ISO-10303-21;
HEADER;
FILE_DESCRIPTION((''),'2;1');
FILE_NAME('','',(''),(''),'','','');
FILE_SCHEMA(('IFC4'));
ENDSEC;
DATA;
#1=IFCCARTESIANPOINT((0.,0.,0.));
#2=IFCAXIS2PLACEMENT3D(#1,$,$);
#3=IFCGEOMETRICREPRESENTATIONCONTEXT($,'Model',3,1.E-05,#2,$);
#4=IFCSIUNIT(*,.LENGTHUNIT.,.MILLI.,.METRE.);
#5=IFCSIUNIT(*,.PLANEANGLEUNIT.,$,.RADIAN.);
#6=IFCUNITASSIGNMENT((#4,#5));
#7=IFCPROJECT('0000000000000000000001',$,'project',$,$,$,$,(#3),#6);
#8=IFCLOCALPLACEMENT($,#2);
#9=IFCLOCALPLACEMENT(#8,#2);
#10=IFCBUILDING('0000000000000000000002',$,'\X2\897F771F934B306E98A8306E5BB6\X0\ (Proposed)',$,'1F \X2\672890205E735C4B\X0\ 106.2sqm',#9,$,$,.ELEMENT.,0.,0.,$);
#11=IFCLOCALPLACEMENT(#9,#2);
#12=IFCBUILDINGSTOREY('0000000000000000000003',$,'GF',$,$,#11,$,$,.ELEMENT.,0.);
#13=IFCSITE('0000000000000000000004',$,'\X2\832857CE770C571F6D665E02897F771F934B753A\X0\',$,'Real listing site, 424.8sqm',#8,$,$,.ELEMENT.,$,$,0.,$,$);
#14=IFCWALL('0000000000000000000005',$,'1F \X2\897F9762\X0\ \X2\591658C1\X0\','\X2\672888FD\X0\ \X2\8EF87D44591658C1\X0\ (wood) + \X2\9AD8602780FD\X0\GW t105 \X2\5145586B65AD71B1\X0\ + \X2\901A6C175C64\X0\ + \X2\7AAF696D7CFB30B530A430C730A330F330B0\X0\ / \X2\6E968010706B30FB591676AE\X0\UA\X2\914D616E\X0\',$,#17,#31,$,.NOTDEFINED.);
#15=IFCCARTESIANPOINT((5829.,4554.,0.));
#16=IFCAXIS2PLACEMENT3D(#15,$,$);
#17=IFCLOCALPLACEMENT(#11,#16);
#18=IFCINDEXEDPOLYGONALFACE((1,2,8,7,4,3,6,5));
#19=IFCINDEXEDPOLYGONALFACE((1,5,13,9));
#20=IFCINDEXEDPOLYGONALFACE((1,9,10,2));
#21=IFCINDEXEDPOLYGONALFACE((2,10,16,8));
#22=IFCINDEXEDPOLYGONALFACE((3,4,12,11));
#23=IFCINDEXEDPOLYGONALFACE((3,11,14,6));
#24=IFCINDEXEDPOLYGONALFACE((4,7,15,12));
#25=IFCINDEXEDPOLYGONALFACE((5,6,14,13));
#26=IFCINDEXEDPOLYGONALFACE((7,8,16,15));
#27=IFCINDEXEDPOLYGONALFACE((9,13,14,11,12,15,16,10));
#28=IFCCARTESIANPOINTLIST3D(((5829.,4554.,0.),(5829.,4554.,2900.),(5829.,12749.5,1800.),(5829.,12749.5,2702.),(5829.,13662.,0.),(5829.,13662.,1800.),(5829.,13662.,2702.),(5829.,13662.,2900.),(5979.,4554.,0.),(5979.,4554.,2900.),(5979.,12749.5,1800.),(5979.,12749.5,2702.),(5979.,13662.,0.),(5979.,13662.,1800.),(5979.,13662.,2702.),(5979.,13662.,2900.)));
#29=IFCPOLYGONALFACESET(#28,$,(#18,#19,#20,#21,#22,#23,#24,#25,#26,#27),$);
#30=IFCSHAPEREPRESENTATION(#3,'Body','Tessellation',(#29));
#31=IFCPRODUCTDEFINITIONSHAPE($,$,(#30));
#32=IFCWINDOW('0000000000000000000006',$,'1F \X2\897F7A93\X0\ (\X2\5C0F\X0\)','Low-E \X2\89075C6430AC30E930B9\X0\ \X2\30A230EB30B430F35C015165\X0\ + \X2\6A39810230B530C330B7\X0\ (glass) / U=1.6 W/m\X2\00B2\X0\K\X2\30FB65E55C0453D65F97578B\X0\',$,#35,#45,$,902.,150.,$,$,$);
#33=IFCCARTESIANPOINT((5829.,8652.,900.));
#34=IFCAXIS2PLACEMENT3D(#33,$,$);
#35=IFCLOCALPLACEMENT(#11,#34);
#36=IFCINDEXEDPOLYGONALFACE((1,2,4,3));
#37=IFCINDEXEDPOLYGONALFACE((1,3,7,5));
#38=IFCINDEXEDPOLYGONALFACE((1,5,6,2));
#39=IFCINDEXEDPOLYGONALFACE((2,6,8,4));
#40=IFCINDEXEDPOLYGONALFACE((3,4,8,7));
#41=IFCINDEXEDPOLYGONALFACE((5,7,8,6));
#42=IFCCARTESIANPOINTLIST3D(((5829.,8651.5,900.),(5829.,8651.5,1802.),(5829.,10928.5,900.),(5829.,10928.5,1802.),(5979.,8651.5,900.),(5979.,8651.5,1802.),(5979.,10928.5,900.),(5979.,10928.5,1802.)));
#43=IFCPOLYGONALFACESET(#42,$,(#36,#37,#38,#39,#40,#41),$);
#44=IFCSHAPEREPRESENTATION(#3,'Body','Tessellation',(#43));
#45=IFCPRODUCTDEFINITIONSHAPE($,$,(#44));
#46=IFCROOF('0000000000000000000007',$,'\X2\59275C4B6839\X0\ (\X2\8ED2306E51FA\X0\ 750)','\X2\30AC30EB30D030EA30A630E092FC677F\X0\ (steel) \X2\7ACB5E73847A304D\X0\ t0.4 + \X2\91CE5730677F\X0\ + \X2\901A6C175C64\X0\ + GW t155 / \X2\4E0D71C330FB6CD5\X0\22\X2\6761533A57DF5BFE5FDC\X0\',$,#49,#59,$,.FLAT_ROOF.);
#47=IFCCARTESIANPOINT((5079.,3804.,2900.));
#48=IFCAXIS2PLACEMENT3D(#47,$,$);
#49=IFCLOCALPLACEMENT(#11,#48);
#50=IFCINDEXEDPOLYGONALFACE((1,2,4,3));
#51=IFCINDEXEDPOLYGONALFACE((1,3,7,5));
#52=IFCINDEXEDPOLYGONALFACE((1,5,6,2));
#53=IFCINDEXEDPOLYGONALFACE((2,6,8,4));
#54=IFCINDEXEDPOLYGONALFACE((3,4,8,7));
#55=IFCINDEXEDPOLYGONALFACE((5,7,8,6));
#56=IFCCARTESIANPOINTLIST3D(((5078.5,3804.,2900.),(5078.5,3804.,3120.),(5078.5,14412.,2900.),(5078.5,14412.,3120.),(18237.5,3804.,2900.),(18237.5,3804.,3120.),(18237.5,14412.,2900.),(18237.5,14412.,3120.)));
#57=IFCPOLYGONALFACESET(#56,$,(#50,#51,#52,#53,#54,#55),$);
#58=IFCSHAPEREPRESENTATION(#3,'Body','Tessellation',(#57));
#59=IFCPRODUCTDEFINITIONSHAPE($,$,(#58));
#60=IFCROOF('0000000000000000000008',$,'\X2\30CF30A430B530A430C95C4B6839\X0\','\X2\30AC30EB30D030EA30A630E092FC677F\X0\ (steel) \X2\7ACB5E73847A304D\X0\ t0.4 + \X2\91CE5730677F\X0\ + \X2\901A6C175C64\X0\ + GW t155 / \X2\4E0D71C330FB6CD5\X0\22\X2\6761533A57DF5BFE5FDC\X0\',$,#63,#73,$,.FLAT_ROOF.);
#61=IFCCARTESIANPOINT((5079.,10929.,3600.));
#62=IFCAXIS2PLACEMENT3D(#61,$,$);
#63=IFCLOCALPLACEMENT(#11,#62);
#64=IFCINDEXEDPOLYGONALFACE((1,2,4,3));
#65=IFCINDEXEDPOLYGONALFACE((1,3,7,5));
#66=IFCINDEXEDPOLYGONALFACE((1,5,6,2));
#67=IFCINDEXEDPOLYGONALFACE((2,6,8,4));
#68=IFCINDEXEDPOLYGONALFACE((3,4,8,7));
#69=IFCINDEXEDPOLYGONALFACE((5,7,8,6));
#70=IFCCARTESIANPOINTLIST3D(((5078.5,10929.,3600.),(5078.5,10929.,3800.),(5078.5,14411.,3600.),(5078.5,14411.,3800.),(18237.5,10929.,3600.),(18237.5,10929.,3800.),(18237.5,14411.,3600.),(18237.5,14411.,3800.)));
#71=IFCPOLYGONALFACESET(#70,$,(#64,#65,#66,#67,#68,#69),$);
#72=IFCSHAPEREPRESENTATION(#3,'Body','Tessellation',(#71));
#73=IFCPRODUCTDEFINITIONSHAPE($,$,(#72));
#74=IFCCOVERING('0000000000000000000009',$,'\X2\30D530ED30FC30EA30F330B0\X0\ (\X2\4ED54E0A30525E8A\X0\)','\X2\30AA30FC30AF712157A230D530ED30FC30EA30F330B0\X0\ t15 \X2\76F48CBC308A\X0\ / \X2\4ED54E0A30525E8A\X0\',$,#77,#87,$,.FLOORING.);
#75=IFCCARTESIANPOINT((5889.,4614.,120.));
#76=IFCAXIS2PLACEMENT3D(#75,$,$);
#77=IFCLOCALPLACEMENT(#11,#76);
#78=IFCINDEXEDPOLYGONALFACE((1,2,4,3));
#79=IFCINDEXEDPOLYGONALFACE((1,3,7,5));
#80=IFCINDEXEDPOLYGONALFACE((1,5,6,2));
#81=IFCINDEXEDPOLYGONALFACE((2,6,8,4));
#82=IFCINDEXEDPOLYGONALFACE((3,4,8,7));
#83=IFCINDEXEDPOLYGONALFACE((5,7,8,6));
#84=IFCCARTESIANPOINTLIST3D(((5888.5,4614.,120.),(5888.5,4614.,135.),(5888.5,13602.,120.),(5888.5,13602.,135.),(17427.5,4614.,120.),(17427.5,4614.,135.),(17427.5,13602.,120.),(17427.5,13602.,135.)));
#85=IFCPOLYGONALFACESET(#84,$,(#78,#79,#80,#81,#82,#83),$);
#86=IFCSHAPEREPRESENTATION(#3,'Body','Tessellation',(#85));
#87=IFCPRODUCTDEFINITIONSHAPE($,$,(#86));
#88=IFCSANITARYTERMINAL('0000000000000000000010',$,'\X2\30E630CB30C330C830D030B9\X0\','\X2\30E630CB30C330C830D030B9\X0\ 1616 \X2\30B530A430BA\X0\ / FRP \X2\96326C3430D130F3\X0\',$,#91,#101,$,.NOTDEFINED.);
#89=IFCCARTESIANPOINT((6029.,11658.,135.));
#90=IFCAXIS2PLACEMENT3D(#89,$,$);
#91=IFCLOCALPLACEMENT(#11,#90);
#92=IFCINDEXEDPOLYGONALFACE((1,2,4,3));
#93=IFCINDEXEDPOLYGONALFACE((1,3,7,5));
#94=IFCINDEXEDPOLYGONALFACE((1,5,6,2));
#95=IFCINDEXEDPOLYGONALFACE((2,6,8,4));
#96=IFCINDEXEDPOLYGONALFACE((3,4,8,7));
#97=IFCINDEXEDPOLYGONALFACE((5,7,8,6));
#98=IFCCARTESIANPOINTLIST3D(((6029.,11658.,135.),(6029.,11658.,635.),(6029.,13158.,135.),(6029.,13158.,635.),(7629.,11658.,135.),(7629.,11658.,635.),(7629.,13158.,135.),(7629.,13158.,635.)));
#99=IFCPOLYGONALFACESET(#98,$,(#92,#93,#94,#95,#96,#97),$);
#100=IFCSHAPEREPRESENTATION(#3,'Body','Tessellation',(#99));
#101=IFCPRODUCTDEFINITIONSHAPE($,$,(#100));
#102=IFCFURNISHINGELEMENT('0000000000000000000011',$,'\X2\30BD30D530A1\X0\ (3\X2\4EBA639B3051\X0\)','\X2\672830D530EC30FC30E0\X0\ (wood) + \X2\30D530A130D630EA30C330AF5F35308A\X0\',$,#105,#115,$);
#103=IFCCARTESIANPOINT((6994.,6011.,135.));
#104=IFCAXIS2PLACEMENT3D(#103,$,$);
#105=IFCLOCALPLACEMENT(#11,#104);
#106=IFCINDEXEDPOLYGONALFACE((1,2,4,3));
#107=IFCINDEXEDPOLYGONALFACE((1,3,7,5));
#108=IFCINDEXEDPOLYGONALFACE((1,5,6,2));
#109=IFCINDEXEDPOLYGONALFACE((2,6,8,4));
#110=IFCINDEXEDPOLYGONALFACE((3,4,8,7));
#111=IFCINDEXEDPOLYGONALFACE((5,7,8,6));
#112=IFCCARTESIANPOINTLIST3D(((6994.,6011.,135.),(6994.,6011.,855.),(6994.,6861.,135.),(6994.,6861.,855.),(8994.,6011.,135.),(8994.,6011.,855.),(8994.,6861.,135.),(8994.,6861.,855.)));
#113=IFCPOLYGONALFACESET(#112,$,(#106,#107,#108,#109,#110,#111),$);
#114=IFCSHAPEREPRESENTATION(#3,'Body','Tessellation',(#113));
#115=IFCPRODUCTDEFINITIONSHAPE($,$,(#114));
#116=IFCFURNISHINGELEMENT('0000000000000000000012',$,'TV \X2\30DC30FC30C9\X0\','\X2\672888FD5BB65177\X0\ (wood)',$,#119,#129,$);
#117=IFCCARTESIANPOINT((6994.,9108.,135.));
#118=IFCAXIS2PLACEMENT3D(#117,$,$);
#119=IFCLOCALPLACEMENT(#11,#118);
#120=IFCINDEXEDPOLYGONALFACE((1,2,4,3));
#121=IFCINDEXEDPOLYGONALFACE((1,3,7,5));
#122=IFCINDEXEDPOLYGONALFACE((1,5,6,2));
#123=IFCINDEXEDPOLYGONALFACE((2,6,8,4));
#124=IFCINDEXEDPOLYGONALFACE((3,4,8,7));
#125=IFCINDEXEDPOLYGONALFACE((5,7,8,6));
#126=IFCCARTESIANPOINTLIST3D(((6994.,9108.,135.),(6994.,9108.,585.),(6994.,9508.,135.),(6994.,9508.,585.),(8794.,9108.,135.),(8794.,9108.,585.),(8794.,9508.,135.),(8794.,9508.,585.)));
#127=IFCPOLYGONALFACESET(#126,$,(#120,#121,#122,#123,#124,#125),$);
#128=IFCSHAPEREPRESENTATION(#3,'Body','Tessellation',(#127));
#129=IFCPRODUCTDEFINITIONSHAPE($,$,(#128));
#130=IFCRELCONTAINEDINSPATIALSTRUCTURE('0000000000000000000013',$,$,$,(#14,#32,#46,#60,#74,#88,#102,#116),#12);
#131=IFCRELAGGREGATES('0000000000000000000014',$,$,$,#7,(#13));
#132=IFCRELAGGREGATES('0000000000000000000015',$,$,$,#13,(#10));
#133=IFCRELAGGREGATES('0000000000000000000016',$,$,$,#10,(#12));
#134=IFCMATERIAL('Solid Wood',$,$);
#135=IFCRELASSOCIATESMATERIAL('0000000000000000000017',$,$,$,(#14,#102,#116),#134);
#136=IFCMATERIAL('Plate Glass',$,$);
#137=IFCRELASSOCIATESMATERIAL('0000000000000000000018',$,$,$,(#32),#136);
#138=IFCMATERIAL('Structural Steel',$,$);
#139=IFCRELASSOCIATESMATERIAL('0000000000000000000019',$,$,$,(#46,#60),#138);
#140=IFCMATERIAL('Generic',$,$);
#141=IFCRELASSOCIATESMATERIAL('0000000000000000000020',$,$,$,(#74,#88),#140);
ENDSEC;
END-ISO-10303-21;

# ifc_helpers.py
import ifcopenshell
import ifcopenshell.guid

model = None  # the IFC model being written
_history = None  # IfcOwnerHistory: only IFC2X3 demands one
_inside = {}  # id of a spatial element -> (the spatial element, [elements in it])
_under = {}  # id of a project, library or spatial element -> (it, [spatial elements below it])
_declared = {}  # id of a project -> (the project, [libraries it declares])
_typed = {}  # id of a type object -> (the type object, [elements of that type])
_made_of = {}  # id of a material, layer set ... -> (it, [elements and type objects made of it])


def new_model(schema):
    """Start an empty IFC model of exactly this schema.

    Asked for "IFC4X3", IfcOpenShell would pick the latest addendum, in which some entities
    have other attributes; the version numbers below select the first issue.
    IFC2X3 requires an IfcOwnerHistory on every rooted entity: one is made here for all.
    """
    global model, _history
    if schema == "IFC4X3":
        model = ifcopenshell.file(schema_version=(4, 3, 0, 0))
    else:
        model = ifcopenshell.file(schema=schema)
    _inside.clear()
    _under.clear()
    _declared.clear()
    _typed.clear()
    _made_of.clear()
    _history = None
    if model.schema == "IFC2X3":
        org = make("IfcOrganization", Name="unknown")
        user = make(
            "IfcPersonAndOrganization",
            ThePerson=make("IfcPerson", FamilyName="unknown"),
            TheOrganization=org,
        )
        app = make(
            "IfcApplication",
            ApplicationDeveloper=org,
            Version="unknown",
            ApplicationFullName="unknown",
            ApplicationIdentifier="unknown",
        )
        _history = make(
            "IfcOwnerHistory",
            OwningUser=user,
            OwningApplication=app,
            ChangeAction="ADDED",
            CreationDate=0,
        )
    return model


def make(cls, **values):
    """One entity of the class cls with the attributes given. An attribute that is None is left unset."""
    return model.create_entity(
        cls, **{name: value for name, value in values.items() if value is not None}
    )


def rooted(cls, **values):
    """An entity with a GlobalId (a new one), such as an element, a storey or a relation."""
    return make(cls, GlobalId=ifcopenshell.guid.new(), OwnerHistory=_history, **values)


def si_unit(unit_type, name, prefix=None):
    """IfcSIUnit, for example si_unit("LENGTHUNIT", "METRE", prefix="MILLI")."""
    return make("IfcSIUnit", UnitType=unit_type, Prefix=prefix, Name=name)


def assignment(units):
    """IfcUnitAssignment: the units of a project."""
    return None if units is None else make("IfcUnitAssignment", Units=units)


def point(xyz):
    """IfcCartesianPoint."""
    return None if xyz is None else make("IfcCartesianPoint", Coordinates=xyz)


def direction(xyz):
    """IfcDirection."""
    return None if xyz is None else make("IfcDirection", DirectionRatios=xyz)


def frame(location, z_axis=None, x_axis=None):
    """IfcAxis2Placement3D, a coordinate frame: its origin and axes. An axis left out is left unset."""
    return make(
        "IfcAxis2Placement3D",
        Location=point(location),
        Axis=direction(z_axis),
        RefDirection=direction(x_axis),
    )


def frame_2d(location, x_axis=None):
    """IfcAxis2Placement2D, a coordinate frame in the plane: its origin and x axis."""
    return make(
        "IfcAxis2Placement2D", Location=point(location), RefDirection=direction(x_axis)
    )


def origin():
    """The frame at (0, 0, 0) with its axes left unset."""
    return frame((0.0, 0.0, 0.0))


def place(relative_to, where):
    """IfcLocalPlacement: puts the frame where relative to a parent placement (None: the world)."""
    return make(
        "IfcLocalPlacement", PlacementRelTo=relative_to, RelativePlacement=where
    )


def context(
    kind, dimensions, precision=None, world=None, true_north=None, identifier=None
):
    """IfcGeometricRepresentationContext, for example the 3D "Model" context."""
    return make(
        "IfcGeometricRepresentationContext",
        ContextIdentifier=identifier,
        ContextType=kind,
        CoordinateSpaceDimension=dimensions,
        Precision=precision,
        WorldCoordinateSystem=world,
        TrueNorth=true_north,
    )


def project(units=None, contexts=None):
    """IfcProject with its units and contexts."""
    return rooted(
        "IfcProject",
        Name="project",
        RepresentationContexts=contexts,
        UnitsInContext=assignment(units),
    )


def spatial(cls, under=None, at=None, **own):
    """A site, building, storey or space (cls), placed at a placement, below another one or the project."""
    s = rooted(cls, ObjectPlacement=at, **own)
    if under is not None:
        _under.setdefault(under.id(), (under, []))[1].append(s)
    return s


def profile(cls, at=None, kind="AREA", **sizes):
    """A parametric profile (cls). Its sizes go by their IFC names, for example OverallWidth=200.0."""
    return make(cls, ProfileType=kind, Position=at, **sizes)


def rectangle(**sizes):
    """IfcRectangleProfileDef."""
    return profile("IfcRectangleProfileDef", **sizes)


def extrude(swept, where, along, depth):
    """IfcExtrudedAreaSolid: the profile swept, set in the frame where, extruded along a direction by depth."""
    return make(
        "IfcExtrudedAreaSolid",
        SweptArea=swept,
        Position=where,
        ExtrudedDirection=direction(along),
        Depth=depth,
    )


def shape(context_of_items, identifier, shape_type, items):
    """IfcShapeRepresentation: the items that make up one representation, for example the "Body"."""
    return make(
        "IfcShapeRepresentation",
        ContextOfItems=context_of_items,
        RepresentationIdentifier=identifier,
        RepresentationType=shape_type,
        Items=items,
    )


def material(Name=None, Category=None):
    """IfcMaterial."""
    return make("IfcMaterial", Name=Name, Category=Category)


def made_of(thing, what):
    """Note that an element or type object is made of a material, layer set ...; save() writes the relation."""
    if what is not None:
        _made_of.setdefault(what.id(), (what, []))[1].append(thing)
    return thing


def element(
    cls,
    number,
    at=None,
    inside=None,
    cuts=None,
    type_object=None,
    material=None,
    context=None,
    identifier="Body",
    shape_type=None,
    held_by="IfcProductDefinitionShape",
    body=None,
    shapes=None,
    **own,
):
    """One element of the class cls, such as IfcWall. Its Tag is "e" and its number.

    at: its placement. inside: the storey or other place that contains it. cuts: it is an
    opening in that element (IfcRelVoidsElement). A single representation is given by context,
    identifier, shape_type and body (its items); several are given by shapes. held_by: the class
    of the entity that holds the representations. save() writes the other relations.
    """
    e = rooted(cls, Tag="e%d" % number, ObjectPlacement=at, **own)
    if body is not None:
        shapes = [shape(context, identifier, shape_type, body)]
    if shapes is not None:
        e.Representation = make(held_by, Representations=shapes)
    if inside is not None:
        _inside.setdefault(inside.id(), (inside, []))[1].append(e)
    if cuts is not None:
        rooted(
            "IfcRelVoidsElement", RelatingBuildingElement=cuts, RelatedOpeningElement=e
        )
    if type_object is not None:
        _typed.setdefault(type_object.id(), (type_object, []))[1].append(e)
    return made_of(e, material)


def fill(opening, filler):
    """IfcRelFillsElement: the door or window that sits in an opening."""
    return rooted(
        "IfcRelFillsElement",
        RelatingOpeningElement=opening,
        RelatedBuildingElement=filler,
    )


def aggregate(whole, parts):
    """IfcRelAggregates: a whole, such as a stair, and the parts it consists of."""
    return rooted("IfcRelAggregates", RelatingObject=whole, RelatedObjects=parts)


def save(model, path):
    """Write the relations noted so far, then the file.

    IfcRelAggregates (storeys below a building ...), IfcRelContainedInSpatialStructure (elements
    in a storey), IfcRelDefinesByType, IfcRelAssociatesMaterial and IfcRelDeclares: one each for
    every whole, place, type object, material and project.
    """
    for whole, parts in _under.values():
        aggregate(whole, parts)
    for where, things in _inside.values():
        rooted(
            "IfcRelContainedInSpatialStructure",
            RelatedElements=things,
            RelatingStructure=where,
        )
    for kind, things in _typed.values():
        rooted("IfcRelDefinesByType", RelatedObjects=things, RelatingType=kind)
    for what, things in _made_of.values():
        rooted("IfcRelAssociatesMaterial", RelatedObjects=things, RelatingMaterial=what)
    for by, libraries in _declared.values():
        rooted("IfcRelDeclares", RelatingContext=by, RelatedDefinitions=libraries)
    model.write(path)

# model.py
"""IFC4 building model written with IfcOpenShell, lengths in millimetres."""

from ifc_helpers import new_model, si_unit, frame, frame_2d, origin, place, context, project, spatial, rectangle, extrude, material, element, fill, save


model = new_model("IFC4")

# Units and contexts
model_context = context("Model", 3, precision=1e-05, world=origin())
ifc_project = project(units=[si_unit("LENGTHUNIT", "METRE", prefix="MILLI"), si_unit("PLANEANGLEUNIT", "RADIAN")], contexts=[model_context])

# Site, building, storey
site_placement = place(None, origin())
site = spatial("IfcSite", under=ifc_project, at=site_placement, Name="茨城県土浦市西真鍋町", ObjectType="Real listing site, 424.8sqm", CompositionType="ELEMENT", RefElevation=0.0)
building_placement = place(site_placement, origin())
building = spatial("IfcBuilding", under=site, at=building_placement, Name="西真鍋の風の家 (Proposed)", ObjectType="1F 木造平屋 106.2sqm", CompositionType="ELEMENT", ElevationOfRefHeight=0.0, ElevationOfTerrain=0.0)
storey_placement = place(building_placement, origin())
storey = spatial("IfcBuildingStorey", under=building, at=storey_placement, Name="GF", CompositionType="ELEMENT", Elevation=0.0)

# Shared definitions
ifc_material_1 = material(Name="Solid Wood")

# Shared definitions
ifc_material_2 = material(Name="Plate Glass")

# Wall, opening, window
wall_1_placement = place(storey_placement, frame((5829.0, 4554.0, 0.0)))
wall_1 = element("IfcWall", 1, at=wall_1_placement, inside=storey, material=ifc_material_1, Name="1F 西面 外壁", Description="木製 軸組外壁 (wood) + 高性能GW t105 充填断熱 + 通気層 + 窯業系サイディング / 準耐火・外皮UA配慮", PredefinedType="NOTDEFINED", context=model_context, shape_type="SweptSolid", body=[
    extrude(rectangle(XDim=150.0, YDim=9108.0, at=frame_2d((75.0, 4554.0))), frame((5829.0, 4554.0, 0.0)), (0.0, 0.0, 1.0), 2900.0),
])
opening_1_placement = place(storey_placement, frame((5829.0, 8652.0, 900.0)))
opening_1 = element("IfcOpeningElement", 2, at=opening_1_placement, cuts=wall_1, PredefinedType="NOTDEFINED", context=model_context, shape_type="SweptSolid", body=[
    extrude(rectangle(XDim=150.0, YDim=2277.0, at=frame_2d((75.0, 1138.0))), frame((5829.0, 8652.0, 900.0)), (0.0, 0.0, 1.0), 902.0),
])
window_1_placement = place(storey_placement, frame((5829.0, 8652.0, 900.0)))
window_1 = element("IfcWindow", 3, at=window_1_placement, inside=storey, material=ifc_material_2, Name="1F 西窓 (小)", Description="Low-E 複層ガラス アルゴン封入 + 樹脂サッシ (glass) / U=1.6 W/m²K・日射取得型", OverallHeight=902.0, OverallWidth=150.0, context=model_context, shape_type="SweptSolid", body=[
    extrude(rectangle(XDim=150.0, YDim=2277.0, at=frame_2d((75.0, 1138.0))), frame((5829.0, 8652.0, 900.0)), (0.0, 0.0, 1.0), 902.0),
])
fill(opening_1, window_1)

# Roofs
ifc_material_3 = material(Name="Structural Steel")
roof_1_placement = place(storey_placement, frame((5079.0, 3804.0, 2900.0)))
element("IfcRoof", 4, at=roof_1_placement, inside=storey, material=ifc_material_3, Name="大屋根 (軒の出 750)", Description="ガルバリウム鋼板 (steel) 立平葺き t0.4 + 野地板 + 通気層 + GW t155 / 不燃・法22条区域対応", PredefinedType="FLAT_ROOF", context=model_context, shape_type="SweptSolid", body=[
    extrude(rectangle(XDim=13159.0, YDim=10608.0, at=frame_2d((6579.0, 5304.0))), frame((5079.0, 3804.0, 2900.0)), (0.0, 0.0, 1.0), 220.0),
])
roof_2_placement = place(storey_placement, frame((5079.0, 10929.0, 3600.0)))
element("IfcRoof", 5, at=roof_2_placement, inside=storey, material=ifc_material_3, Name="ハイサイド屋根", Description="ガルバリウム鋼板 (steel) 立平葺き t0.4 + 野地板 + 通気層 + GW t155 / 不燃・法22条区域対応", PredefinedType="FLAT_ROOF", context=model_context, shape_type="SweptSolid", body=[
    extrude(rectangle(XDim=13159.0, YDim=3482.0, at=frame_2d((6579.0, 1741.0))), frame((5079.0, 10929.0, 3600.0)), (0.0, 0.0, 1.0), 200.0),
])

# Covering
ifc_material_4 = material(Name="Generic")
covering_placement = place(storey_placement, frame((5889.0, 4614.0, 120.0)))
element("IfcCovering", 6, at=covering_placement, inside=storey, material=ifc_material_4, Name="フローリング (仕上げ床)", Description="オーク無垢フローリング t15 直貼り / 仕上げ床", PredefinedType="FLOORING", context=model_context, shape_type="SweptSolid", body=[
    extrude(rectangle(XDim=11539.0, YDim=8988.0, at=frame_2d((5769.0, 4494.0))), frame((5889.0, 4614.0, 120.0)), (0.0, 0.0, 1.0), 15.0),
])

# Sanitary terminal
sanitary_terminal_placement = place(storey_placement, frame((6029.0, 11658.0, 135.0)))
element("IfcSanitaryTerminal", 7, at=sanitary_terminal_placement, inside=storey, material=ifc_material_4, Name="ユニットバス", Description="ユニットバス 1616 サイズ / FRP 防水パン", PredefinedType="NOTDEFINED", context=model_context, shape_type="SweptSolid", body=[
    extrude(rectangle(XDim=1600.0, YDim=1500.0, at=frame_2d((800.0, 750.0))), frame((6029.0, 11658.0, 135.0)), (0.0, 0.0, 1.0), 500.0),
])

# Furnishing elements
furnishing_1_placement = place(storey_placement, frame((6994.0, 6011.0, 135.0)))
element("IfcFurnishingElement", 8, at=furnishing_1_placement, inside=storey, material=ifc_material_1, Name="ソファ (3人掛け)", Description="木フレーム (wood) + ファブリック張り", context=model_context, shape_type="SweptSolid", body=[
    extrude(rectangle(XDim=2000.0, YDim=850.0, at=frame_2d((1000.0, 425.0))), frame((6994.0, 6011.0, 135.0)), (0.0, 0.0, 1.0), 720.0),
])
furnishing_2_placement = place(storey_placement, frame((6994.0, 9108.0, 135.0)))
element("IfcFurnishingElement", 9, at=furnishing_2_placement, inside=storey, material=ifc_material_1, Name="TV ボード", Description="木製家具 (wood)", context=model_context, shape_type="SweptSolid", body=[
    extrude(rectangle(XDim=1800.0, YDim=400.0, at=frame_2d((900.0, 200.0))), frame((6994.0, 9108.0, 135.0)), (0.0, 0.0, 1.0), 450.0),
])

save(model, "model.ifc")
